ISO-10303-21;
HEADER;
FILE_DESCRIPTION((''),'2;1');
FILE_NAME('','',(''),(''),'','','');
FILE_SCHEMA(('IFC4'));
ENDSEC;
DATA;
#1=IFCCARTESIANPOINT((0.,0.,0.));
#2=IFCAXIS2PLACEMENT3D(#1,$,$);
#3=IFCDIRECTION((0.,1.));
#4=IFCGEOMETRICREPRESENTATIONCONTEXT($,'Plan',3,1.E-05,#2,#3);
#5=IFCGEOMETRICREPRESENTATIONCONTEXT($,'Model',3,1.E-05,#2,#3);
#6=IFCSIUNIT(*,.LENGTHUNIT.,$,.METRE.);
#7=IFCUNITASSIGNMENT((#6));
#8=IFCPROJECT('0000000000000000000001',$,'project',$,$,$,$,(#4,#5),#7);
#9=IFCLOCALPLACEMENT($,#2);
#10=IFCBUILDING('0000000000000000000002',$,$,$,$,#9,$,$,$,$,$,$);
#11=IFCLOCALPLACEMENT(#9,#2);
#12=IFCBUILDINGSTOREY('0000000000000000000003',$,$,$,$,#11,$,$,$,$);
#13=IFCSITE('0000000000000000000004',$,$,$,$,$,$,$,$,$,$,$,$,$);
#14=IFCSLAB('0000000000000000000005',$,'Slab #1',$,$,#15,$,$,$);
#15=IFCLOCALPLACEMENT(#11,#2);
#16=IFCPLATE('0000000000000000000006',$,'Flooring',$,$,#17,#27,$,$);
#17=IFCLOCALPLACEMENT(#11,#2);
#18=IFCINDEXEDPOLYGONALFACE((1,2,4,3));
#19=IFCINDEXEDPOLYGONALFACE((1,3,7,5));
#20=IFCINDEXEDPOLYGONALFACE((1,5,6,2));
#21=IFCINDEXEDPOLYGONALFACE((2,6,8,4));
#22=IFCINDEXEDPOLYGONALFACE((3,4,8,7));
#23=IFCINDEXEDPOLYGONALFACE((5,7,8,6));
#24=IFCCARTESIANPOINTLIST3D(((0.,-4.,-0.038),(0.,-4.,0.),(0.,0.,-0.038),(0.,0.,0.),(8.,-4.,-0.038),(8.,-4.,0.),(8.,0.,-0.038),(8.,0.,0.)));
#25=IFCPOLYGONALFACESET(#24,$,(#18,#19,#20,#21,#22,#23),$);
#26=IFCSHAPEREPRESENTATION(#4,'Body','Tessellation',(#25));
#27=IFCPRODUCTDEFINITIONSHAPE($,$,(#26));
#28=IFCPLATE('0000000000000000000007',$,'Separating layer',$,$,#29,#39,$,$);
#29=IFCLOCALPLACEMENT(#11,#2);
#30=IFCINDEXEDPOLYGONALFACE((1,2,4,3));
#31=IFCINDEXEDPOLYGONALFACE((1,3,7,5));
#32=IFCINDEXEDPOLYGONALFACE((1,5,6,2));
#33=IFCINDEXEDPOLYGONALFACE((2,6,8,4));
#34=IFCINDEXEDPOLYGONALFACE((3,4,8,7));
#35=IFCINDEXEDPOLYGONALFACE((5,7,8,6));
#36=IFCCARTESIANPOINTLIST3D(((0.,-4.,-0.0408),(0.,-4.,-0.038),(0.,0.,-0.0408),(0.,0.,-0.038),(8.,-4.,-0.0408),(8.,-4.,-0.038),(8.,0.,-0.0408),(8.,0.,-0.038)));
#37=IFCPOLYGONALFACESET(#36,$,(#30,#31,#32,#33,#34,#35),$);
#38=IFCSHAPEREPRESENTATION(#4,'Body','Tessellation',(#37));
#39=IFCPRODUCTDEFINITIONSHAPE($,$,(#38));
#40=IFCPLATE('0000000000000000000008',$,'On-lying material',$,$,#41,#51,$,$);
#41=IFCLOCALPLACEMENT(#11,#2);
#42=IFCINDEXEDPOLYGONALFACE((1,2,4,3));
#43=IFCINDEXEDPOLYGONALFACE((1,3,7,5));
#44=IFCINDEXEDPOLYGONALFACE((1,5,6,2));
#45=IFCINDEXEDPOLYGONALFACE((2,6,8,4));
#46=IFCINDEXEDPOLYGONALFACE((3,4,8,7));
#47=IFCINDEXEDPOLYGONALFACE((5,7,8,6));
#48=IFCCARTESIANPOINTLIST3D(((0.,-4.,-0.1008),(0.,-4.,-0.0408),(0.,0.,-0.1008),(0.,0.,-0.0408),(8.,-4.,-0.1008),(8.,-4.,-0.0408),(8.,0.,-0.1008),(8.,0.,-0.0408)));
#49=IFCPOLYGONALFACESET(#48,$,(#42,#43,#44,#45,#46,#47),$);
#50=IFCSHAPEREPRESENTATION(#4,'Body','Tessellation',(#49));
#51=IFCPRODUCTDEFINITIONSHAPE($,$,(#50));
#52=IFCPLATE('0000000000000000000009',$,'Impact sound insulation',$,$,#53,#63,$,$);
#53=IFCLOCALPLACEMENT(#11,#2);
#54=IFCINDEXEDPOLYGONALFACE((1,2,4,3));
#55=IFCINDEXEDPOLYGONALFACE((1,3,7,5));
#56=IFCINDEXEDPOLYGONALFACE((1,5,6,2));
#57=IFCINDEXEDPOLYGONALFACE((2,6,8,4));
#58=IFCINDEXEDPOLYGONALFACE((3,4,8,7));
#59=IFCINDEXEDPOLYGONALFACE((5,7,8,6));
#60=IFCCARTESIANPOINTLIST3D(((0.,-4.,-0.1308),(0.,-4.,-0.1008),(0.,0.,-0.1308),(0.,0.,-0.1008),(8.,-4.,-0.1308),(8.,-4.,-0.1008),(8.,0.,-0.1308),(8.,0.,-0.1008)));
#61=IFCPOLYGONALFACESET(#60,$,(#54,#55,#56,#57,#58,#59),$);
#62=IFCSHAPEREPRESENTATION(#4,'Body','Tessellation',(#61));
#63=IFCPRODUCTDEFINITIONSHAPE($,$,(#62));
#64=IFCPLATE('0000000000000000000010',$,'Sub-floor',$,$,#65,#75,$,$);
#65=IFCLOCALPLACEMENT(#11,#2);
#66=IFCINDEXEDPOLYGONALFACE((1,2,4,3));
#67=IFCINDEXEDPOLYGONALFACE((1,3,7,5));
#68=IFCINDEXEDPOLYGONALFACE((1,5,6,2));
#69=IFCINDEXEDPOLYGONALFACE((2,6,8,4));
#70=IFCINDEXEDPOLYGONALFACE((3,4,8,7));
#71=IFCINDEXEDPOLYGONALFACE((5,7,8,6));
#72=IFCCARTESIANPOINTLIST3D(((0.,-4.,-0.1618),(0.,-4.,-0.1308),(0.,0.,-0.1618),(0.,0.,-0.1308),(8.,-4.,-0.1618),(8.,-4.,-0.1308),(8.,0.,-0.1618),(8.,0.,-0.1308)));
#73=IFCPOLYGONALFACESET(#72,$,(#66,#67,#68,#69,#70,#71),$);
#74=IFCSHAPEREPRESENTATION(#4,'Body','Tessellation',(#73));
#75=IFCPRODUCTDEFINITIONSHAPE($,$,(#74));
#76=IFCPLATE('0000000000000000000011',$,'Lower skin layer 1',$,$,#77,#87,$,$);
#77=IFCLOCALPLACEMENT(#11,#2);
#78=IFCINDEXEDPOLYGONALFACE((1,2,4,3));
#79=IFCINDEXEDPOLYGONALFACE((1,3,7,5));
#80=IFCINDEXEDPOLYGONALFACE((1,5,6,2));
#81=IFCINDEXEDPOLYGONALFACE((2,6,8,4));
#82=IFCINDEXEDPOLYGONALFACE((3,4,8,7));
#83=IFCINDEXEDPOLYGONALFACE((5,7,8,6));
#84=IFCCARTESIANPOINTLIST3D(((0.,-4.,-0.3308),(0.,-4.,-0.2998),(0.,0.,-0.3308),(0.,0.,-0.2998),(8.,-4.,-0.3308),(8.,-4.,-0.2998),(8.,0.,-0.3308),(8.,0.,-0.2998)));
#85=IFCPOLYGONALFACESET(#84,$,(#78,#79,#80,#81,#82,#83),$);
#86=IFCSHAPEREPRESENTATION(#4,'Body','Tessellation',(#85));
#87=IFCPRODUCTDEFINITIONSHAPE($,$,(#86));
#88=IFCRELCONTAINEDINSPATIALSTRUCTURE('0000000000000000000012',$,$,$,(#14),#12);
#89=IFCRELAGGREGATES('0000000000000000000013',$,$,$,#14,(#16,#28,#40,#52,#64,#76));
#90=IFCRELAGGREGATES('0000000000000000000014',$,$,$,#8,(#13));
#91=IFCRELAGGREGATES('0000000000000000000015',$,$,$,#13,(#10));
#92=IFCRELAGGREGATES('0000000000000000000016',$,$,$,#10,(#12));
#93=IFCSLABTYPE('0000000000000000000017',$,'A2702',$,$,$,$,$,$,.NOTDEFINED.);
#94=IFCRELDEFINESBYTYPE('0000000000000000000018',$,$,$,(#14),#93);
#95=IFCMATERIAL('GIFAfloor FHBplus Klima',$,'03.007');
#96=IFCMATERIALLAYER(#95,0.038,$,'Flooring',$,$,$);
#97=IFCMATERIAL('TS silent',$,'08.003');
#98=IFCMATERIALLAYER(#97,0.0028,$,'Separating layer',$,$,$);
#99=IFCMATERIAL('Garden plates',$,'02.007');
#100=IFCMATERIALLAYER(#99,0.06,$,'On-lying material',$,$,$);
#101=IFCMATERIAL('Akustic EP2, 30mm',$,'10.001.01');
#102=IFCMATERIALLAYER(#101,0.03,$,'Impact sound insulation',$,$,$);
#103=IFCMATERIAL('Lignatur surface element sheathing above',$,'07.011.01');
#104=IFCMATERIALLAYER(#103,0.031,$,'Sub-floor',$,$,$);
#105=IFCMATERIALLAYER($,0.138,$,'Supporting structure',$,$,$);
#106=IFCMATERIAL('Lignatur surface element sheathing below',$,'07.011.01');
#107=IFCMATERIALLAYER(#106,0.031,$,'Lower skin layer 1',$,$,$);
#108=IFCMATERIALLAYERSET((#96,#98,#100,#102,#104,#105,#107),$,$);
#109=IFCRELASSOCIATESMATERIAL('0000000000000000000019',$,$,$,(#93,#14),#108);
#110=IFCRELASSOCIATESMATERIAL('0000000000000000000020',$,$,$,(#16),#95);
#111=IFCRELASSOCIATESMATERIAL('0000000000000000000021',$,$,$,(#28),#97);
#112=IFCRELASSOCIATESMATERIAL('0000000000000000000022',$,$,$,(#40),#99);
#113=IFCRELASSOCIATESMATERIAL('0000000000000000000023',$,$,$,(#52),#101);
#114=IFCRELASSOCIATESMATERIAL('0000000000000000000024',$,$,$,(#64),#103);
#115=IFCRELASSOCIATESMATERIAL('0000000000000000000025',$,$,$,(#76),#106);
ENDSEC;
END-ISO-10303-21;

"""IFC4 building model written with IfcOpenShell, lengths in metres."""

from ifc_helpers import new_model, si_unit, direction, frame, frame_2d, origin, origin_with_axes, place, context, project, spatial, rectangle, extrude, material, layer, layer_set, type_object, element, aggregate, save


model = new_model("IFC4")

# Units and contexts
plan_context = context("Plan", 3, precision=1e-05, world=origin(), true_north=direction((0.0, 1.0)))
model_context = context("Model", 3, precision=1e-05, world=origin(), true_north=direction((0.0, 1.0)))
ifc_project = project(units=[si_unit("LENGTHUNIT", "METRE")], contexts=[plan_context, model_context])

# Site, building, storey
site = spatial("IfcSite", under=ifc_project)
building_placement = place(None, origin())
building = spatial("IfcBuilding", under=site, at=building_placement)
storey_placement = place(building_placement, origin())
storey = spatial("IfcBuildingStorey", under=building, at=storey_placement)

# Slab, plates
ifc_material_1 = material(Name="GIFAfloor FHBplus Klima", Category="03.007")
ifc_layer_1 = layer(ifc_material_1, 0.038, Name="Flooring")
ifc_material_2 = material(Name="TS silent", Category="08.003")
ifc_layer_2 = layer(ifc_material_2, 0.0028, Name="Separating layer")
ifc_material_3 = material(Name="Garden plates", Category="02.007")
ifc_layer_3 = layer(ifc_material_3, 0.06, Name="On-lying material")
ifc_material_4 = material(Name="Akustic EP2, 30mm", Category="10.001.01")
ifc_layer_4 = layer(ifc_material_4, 0.03, Name="Impact sound insulation")
ifc_material_5 = material(Name="Lignatur surface element sheathing above", Category="07.011.01")
ifc_layer_5 = layer(ifc_material_5, 0.031, Name="Sub-floor")
ifc_layer_6 = layer(None, 0.138, Name="Supporting structure")
ifc_material_6 = material(Name="Lignatur surface element sheathing below", Category="07.011.01")
ifc_layer_7 = layer(ifc_material_6, 0.031, Name="Lower skin layer 1")
ifc_layer_set = layer_set([ifc_layer_1, ifc_layer_2, ifc_layer_3, ifc_layer_4, ifc_layer_5, ifc_layer_6, ifc_layer_7])
slab_type = type_object("IfcSlabType", Name="A2702", PredefinedType="NOTDEFINED", material=ifc_layer_set)
slab_placement = place(None, frame((0.0, 0.0, 0.0), z_axis=(0.0, 0.0, -1.0), x_axis=(1.0, 0.0, 0.0)))
slab = element("IfcSlab", 1, at=slab_placement, inside=storey, type_object=slab_type, material=ifc_layer_set, Name="Slab #1")
plate_1_placement = place(slab_placement, origin())
plate_1 = element("IfcPlate", 2, at=plate_1_placement, material=ifc_material_1, Name="Flooring", context=plan_context, shape_type="SweptSolid", body=[
    extrude(rectangle(XDim=8.0, YDim=4.0, at=frame_2d((4.0, 2.0), x_axis=(1.0, 0.0))), origin_with_axes(), (0.0, 0.0, 1.0), 0.038),
])
plate_2_placement = place(slab_placement, origin())
plate_2 = element("IfcPlate", 3, at=plate_2_placement, material=ifc_material_2, Name="Separating layer", context=plan_context, shape_type="SweptSolid", body=[
    extrude(rectangle(XDim=8.0, YDim=4.0, at=frame_2d((4.0, 2.0), x_axis=(1.0, 0.0))), frame((0.0, 0.0, 0.038), z_axis=(0.0, 0.0, 1.0), x_axis=(1.0, 0.0, 0.0)), (0.0, 0.0, 1.0), 0.0028),
])
plate_3_placement = place(slab_placement, origin())
plate_3 = element("IfcPlate", 4, at=plate_3_placement, material=ifc_material_3, Name="On-lying material", context=plan_context, shape_type="SweptSolid", body=[
    extrude(rectangle(XDim=8.0, YDim=4.0, at=frame_2d((4.0, 2.0), x_axis=(1.0, 0.0))), frame((0.0, 0.0, 0.0408), z_axis=(0.0, 0.0, 1.0), x_axis=(1.0, 0.0, 0.0)), (0.0, 0.0, 1.0), 0.06),
])
plate_4_placement = place(slab_placement, origin())
plate_4 = element("IfcPlate", 5, at=plate_4_placement, material=ifc_material_4, Name="Impact sound insulation", context=plan_context, shape_type="SweptSolid", body=[
    extrude(rectangle(XDim=8.0, YDim=4.0, at=frame_2d((4.0, 2.0), x_axis=(1.0, 0.0))), frame((0.0, 0.0, 0.1008), z_axis=(0.0, 0.0, 1.0), x_axis=(1.0, 0.0, 0.0)), (0.0, 0.0, 1.0), 0.03),
])
plate_5_placement = place(slab_placement, origin())
plate_5 = element("IfcPlate", 6, at=plate_5_placement, material=ifc_material_5, Name="Sub-floor", context=plan_context, shape_type="SweptSolid", body=[
    extrude(rectangle(XDim=8.0, YDim=4.0, at=frame_2d((4.0, 2.0), x_axis=(1.0, 0.0))), frame((0.0, 0.0, 0.1308), z_axis=(0.0, 0.0, 1.0), x_axis=(1.0, 0.0, 0.0)), (0.0, 0.0, 1.0), 0.031),
])
plate_6_placement = place(slab_placement, origin())
plate_6 = element("IfcPlate", 7, at=plate_6_placement, material=ifc_material_6, Name="Lower skin layer 1", context=plan_context, shape_type="SweptSolid", body=[
    extrude(rectangle(XDim=8.0, YDim=4.0, at=frame_2d((4.0, 2.0), x_axis=(1.0, 0.0))), frame((0.0, 0.0, 0.2998), z_axis=(0.0, 0.0, 1.0), x_axis=(1.0, 0.0, 0.0)), (0.0, 0.0, 1.0), 0.031),
])
aggregate(slab, [plate_1, plate_2, plate_3, plate_4, plate_5, plate_6])

save(model, "model.ifc")
